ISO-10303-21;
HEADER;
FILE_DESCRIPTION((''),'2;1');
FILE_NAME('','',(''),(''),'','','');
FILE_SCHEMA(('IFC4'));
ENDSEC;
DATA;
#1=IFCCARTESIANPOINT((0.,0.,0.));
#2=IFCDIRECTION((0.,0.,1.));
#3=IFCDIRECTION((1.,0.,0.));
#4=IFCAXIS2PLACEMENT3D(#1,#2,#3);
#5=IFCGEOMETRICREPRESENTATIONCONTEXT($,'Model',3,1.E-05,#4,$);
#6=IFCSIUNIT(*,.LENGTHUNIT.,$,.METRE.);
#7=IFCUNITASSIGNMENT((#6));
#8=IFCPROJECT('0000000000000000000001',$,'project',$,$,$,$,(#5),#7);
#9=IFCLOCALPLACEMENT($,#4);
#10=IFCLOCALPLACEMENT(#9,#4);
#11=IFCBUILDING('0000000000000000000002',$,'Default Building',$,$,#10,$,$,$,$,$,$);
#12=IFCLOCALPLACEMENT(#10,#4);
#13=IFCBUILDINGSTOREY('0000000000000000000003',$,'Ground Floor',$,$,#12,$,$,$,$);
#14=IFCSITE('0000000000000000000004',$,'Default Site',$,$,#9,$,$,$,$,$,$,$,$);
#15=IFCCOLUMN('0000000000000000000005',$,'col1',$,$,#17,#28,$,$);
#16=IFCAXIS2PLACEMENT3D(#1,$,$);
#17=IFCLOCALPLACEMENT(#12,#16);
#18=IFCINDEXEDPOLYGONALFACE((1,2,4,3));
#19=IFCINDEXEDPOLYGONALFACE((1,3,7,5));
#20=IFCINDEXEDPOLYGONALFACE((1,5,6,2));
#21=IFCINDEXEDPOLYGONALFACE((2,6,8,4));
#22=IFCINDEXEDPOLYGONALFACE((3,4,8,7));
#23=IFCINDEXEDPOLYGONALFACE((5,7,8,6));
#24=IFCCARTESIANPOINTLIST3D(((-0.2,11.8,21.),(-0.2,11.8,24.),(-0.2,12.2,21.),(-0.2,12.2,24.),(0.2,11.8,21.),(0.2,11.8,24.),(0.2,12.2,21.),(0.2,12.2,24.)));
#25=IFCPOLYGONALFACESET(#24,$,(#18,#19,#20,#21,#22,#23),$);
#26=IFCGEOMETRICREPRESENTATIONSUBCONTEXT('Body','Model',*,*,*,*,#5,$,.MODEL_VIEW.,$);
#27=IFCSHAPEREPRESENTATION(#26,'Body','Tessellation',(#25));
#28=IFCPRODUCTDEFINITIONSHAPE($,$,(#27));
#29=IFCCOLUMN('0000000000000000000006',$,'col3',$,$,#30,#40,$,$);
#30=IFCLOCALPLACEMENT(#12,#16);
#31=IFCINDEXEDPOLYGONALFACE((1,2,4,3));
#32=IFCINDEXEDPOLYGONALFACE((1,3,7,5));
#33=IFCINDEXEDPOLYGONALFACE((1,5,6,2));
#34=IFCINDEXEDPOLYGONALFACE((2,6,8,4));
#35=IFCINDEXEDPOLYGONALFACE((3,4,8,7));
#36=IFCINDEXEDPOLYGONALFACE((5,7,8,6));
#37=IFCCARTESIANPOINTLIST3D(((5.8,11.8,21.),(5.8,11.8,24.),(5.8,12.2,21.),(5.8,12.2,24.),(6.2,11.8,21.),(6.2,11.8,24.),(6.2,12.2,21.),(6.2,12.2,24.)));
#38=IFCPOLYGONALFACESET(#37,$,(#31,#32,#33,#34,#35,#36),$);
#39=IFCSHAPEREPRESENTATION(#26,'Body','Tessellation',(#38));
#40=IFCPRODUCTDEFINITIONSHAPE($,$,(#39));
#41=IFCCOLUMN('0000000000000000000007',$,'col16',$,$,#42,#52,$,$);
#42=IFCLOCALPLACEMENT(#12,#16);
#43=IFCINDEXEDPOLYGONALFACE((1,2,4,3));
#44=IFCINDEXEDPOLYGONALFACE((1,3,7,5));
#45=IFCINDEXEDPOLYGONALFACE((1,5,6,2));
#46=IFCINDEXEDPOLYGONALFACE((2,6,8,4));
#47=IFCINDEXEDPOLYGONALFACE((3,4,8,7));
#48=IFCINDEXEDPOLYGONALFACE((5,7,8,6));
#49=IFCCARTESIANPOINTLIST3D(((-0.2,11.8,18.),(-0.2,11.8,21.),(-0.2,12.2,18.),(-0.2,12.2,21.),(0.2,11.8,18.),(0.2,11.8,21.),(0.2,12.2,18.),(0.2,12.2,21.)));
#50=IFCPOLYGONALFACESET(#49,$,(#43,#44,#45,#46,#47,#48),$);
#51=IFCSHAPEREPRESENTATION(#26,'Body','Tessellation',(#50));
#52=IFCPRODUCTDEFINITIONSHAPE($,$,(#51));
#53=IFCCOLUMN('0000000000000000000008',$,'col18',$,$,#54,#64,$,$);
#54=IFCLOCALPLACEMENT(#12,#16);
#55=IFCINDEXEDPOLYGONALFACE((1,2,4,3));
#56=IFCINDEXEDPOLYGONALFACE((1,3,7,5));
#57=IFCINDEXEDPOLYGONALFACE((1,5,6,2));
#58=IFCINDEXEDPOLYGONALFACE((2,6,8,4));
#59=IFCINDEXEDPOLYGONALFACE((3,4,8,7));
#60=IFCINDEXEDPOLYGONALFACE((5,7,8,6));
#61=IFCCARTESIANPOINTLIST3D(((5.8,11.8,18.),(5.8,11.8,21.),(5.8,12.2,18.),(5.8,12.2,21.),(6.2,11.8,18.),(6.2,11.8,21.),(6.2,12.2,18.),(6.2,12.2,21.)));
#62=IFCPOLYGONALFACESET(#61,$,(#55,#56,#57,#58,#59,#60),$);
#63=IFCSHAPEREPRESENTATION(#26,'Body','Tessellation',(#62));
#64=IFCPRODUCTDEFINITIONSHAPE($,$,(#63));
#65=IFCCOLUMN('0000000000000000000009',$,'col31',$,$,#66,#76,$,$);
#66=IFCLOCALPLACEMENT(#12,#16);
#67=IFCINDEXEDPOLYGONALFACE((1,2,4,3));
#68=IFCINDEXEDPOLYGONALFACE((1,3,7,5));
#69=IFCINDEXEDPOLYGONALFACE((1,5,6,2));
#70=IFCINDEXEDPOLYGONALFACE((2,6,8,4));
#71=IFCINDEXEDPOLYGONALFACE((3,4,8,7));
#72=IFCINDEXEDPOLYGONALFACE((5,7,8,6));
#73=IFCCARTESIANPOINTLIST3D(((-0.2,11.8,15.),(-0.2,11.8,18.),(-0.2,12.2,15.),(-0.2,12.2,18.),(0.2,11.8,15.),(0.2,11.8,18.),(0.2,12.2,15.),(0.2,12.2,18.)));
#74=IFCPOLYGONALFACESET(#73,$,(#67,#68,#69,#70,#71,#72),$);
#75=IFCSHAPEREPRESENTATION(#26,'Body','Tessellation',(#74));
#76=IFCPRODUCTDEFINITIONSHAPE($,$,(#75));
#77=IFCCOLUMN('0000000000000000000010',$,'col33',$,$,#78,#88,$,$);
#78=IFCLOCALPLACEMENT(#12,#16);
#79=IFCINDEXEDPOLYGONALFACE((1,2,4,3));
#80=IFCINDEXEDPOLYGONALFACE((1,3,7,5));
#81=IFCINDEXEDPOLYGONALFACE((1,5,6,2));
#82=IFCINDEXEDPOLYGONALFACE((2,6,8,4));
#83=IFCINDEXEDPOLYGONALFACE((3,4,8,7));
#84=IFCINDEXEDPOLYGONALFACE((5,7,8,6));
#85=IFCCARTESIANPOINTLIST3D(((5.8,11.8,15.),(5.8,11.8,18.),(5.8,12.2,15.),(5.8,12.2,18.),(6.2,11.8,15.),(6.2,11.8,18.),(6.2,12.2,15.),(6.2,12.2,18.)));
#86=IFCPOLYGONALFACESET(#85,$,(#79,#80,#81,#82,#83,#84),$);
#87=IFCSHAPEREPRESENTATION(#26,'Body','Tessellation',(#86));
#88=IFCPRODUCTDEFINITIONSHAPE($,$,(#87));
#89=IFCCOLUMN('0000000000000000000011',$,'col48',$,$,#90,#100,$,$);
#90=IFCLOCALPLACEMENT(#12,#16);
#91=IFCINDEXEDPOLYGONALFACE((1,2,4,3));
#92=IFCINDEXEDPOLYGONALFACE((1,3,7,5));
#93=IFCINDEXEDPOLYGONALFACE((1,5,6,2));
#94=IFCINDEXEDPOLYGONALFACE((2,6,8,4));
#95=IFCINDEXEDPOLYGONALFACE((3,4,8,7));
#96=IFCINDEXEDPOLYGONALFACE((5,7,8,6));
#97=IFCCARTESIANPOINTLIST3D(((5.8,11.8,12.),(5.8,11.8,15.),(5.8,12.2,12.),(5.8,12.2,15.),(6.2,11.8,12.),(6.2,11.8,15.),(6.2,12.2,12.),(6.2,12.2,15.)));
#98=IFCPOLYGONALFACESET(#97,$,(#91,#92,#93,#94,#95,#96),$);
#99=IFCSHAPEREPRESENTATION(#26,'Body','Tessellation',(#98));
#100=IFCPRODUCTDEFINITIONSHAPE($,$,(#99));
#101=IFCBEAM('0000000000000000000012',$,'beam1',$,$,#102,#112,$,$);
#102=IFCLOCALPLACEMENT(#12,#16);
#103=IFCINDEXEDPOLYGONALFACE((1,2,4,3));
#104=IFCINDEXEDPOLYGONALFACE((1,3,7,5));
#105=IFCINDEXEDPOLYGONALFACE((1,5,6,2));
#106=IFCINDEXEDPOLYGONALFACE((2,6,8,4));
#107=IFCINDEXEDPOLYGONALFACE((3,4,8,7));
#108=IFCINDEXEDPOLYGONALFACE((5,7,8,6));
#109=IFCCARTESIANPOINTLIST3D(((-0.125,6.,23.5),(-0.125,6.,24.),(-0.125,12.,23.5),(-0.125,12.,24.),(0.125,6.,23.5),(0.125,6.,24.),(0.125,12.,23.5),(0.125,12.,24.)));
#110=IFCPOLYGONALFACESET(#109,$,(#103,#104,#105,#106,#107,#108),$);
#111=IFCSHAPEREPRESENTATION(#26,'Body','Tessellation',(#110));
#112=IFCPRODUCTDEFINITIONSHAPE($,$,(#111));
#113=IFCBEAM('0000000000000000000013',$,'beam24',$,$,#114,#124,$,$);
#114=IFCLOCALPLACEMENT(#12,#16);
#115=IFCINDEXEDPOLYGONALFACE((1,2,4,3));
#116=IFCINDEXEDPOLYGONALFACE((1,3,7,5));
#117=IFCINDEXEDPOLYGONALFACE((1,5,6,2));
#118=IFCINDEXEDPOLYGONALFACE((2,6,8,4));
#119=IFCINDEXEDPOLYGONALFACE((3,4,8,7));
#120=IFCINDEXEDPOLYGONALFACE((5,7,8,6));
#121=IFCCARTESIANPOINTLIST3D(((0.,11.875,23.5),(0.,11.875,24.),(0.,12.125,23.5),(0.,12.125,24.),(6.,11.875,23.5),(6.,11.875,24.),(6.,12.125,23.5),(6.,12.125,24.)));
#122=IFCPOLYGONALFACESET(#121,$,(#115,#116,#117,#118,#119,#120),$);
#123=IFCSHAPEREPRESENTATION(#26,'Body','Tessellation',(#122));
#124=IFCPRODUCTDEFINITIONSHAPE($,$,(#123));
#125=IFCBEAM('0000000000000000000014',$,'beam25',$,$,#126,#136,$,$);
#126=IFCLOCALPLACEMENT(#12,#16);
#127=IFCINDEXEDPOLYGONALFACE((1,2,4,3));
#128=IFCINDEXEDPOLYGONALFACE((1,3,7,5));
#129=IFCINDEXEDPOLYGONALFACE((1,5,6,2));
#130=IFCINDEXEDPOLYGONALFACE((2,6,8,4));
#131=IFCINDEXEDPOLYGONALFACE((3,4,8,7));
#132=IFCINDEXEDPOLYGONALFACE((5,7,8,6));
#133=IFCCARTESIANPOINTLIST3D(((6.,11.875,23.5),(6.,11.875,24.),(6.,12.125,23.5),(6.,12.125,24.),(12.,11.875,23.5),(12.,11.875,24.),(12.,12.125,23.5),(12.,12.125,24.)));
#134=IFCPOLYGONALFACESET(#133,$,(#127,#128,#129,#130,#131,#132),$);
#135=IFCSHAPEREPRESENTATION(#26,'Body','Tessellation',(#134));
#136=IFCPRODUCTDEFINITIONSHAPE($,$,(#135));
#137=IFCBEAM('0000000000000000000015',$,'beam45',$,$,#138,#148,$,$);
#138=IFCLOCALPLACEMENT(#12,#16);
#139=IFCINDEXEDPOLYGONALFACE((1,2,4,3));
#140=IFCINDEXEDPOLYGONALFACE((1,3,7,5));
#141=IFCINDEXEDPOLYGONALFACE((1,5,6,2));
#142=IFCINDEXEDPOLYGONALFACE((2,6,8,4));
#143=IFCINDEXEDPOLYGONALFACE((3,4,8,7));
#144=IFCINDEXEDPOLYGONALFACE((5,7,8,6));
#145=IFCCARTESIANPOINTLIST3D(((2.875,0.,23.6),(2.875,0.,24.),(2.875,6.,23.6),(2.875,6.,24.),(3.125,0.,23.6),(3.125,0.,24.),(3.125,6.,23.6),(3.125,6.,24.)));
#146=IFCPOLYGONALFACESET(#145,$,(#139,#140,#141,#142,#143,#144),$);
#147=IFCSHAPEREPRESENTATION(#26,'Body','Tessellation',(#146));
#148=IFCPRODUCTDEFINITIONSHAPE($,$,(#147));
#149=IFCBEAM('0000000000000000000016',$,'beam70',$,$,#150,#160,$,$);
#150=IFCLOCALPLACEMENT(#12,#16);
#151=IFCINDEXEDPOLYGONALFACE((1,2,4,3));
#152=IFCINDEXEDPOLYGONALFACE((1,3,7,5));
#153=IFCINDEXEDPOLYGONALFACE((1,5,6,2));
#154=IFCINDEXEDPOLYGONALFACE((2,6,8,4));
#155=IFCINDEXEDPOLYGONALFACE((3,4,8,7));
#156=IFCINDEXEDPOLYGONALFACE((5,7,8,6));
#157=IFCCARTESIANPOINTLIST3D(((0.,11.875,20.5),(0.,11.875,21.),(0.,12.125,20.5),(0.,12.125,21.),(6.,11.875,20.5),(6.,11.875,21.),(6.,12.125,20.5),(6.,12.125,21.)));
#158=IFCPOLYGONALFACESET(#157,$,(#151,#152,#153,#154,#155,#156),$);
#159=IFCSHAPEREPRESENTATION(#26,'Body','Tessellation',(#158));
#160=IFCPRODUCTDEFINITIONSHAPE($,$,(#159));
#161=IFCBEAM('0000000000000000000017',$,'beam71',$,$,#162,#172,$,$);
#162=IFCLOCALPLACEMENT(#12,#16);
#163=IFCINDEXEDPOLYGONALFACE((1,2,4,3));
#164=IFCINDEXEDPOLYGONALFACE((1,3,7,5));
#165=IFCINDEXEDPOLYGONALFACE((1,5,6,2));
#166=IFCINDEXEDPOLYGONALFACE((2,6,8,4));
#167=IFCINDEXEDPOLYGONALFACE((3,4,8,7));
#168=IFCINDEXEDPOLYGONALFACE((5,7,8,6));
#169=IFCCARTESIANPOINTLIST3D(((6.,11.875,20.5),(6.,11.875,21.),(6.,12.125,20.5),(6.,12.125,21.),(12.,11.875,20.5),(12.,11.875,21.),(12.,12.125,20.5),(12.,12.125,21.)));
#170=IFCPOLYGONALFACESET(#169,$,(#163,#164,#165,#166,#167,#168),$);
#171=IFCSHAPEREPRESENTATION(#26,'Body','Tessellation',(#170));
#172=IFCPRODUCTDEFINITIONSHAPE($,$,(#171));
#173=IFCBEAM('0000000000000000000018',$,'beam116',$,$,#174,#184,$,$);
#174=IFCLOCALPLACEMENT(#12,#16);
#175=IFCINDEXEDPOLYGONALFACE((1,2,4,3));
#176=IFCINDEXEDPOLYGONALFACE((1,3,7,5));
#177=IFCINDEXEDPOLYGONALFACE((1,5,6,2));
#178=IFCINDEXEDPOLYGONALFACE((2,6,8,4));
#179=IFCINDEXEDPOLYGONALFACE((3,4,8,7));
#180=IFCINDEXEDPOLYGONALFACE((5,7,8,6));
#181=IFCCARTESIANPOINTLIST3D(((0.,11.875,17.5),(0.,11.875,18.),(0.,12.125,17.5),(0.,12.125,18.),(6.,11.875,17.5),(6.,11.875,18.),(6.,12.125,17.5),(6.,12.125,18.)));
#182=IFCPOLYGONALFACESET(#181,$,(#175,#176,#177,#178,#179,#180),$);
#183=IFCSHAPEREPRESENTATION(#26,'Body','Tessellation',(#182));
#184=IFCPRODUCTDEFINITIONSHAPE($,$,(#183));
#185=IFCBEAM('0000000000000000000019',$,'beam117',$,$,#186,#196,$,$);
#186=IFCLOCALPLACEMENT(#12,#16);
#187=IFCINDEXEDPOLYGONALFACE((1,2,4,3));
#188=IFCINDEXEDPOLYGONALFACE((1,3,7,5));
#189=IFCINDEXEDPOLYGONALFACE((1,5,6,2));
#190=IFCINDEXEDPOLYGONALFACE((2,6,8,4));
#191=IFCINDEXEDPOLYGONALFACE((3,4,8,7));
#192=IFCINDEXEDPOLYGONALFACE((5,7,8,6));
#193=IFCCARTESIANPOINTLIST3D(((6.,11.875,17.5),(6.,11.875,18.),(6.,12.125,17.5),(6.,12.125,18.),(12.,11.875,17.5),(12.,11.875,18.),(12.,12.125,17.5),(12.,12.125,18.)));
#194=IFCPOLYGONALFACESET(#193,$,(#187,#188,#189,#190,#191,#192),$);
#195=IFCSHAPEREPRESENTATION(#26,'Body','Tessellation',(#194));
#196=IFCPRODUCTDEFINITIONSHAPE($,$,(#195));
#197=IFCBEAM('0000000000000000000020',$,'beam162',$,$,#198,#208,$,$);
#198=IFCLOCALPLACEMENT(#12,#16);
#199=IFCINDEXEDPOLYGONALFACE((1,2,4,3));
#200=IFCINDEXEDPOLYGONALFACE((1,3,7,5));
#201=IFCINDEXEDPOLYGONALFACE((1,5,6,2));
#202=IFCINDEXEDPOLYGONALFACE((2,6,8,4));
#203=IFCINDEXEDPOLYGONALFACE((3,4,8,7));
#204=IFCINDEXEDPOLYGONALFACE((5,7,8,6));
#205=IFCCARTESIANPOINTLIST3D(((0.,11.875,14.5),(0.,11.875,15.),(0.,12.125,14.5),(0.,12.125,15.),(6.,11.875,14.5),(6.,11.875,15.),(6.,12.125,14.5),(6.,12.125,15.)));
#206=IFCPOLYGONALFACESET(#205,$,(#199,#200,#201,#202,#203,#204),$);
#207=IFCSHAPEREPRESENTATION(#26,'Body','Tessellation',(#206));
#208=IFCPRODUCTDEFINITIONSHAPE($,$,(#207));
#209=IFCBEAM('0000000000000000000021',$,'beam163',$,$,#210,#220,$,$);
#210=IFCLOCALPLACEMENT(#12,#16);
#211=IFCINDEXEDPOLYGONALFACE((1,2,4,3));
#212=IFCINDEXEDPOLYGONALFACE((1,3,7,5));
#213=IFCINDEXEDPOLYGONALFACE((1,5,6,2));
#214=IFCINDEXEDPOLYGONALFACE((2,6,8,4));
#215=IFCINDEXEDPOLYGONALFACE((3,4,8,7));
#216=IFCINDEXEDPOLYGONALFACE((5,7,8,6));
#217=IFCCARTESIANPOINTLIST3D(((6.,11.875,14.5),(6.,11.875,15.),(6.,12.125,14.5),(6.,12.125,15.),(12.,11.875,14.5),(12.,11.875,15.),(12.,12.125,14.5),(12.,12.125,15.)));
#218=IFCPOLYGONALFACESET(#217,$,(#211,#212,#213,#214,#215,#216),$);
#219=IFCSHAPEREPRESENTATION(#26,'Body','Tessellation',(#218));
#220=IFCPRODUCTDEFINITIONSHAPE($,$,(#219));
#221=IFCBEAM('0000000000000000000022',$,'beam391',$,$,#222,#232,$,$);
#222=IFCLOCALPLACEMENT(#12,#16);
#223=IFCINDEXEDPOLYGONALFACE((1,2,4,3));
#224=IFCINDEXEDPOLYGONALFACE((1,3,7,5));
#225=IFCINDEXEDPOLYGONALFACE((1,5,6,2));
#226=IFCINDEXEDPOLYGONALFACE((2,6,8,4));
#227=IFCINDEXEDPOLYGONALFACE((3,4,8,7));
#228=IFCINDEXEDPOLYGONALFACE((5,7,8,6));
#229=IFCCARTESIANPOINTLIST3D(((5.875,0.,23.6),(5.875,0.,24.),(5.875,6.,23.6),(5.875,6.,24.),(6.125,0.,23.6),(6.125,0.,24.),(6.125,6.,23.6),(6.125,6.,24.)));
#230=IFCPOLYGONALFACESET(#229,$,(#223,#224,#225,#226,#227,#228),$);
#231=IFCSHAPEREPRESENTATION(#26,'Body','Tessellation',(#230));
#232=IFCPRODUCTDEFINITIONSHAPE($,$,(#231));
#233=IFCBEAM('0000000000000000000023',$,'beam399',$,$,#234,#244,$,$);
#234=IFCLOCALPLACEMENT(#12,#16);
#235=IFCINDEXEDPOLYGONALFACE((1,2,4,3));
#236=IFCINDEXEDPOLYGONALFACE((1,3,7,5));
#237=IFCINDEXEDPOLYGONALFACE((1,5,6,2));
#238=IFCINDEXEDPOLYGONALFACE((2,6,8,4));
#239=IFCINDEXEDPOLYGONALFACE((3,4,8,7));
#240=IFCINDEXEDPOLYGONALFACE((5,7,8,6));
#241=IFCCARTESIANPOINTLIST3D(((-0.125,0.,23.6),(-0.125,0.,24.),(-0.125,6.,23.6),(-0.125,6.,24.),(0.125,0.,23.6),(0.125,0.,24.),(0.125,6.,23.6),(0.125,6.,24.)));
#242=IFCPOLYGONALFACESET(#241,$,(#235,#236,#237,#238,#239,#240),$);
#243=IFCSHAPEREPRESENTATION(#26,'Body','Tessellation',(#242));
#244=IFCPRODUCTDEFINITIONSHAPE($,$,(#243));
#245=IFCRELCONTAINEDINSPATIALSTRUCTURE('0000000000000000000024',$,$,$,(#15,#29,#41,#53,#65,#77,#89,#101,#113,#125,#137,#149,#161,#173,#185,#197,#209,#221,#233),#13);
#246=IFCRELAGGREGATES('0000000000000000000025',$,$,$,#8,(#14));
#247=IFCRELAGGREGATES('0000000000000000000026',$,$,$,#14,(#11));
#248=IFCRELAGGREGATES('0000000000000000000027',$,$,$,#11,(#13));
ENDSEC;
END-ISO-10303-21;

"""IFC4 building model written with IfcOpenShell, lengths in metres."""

from ifc_helpers import new_model, si_unit, frame, origin_with_axes, place, context, subcontext, project, spatial, indexed_curve, outline, extrude, element, save


model = new_model("IFC4")

# Units and contexts
model_context = context("Model", 3, precision=1e-05, world=origin_with_axes())
body_context = subcontext(model_context, "Body", "Model", "MODEL_VIEW")
ifc_project = project(units=[si_unit("LENGTHUNIT", "METRE")], contexts=[model_context])

# Site, building, storey
site_placement = place(None, origin_with_axes())
site = spatial("IfcSite", under=ifc_project, at=site_placement, Name="Default Site")
building_placement = place(site_placement, origin_with_axes())
building = spatial("IfcBuilding", under=site, at=building_placement, Name="Default Building")
storey_placement = place(building_placement, origin_with_axes())
storey = spatial("IfcBuildingStorey", under=building, at=storey_placement, Name="Ground Floor")

# Columns
for number, where, z_axis, x_axis, name in (
    (1, (-0.2, 11.8, 21.0), (0.0, 0.0, 1.0), (1.0, 0.0, 0.0), "col1"),
    (2, (5.8, 11.8, 21.0), (0.0, 0.0, 1.0), (1.0, 0.0, 0.0), "col3"),
    (3, (-0.2, 11.8, 18.0), (0.0, 0.0, 1.0), (1.0, 0.0, 0.0), "col16"),
    (4, (5.8, 11.8, 18.0), (0.0, 0.0, 1.0), (1.0, 0.0, 0.0), "col18"),
    (5, (-0.2, 11.8, 15.0), (0.0, 0.0, 1.0), (1.0, 0.0, 0.0), "col31"),
    (6, (5.8, 11.8, 15.0), (0.0, 0.0, 1.0), (1.0, 0.0, 0.0), "col33"),
    (7, (5.8, 11.8, 12.0), (0.0, 0.0, 1.0), (1.0, 0.0, 0.0), "col48"),
):
    element("IfcColumn", number, at=place(storey_placement, frame(where, z_axis=z_axis, x_axis=x_axis)), inside=storey, Name=name, context=body_context, shape_type="SweptSolid", body=[
        extrude(outline(indexed_curve([(0.0, 0.0), (0.0, 0.4), (0.4, 0.4), (0.4, 0.0), (0.0, 0.0)], self_intersect=False)), origin_with_axes(), (0.0, 0.0, 1.0), 3.0),
    ])

# Beams
for number, where, z_axis, x_axis, name in (
    (8, (0.125, 6.0, 23.5), (0.0, 0.0, 1.0), (0.0, 1.0, 0.0), "beam1"),
    (9, (0.0, 11.875, 23.5), (0.0, 0.0, 1.0), (1.0, 0.0, 0.0), "beam24"),
    (10, (6.0, 11.875, 23.5), (0.0, 0.0, 1.0), (1.0, 0.0, 0.0), "beam25"),
):
    element("IfcBeam", number, at=place(storey_placement, frame(where, z_axis=z_axis, x_axis=x_axis)), inside=storey, Name=name, context=body_context, shape_type="SweptSolid", body=[
        extrude(outline(indexed_curve([(0.0, 0.0), (0.0, 0.25), (6.0, 0.25), (6.0, 0.0), (0.0, 0.0)], self_intersect=False)), origin_with_axes(), (0.0, 0.0, 1.0), 0.5),
    ])
beam_placement = place(storey_placement, frame((2.875, 6.0, 23.6), z_axis=(0.0, 0.0, 1.0), x_axis=(0.0, -1.0, 0.0)))
element("IfcBeam", 11, at=beam_placement, inside=storey, Name="beam45", context=body_context, shape_type="SweptSolid", body=[
    extrude(outline(indexed_curve([(0.0, 0.0), (0.0, 0.25), (6.0, 0.25), (6.0, 0.0), (0.0, 0.0)], self_intersect=False)), origin_with_axes(), (0.0, 0.0, 1.0), 0.4),
])
for number, where, z_axis, x_axis, name in (
    (12, (0.0, 11.875, 20.5), (0.0, 0.0, 1.0), (1.0, 0.0, 0.0), "beam70"),
    (13, (6.0, 11.875, 20.5), (0.0, 0.0, 1.0), (1.0, 0.0, 0.0), "beam71"),
    (14, (0.0, 11.875, 17.5), (0.0, 0.0, 1.0), (1.0, 0.0, 0.0), "beam116"),
    (15, (6.0, 11.875, 17.5), (0.0, 0.0, 1.0), (1.0, 0.0, 0.0), "beam117"),
    (16, (0.0, 11.875, 14.5), (0.0, 0.0, 1.0), (1.0, 0.0, 0.0), "beam162"),
    (17, (6.0, 11.875, 14.5), (0.0, 0.0, 1.0), (1.0, 0.0, 0.0), "beam163"),
):
    element("IfcBeam", number, at=place(storey_placement, frame(where, z_axis=z_axis, x_axis=x_axis)), inside=storey, Name=name, context=body_context, shape_type="SweptSolid", body=[
        extrude(outline(indexed_curve([(0.0, 0.0), (0.0, 0.25), (6.0, 0.25), (6.0, 0.0), (0.0, 0.0)], self_intersect=False)), origin_with_axes(), (0.0, 0.0, 1.0), 0.5),
    ])
for number, where, z_axis, x_axis, name in (
    (18, (5.875, 6.0, 23.6), (0.0, 0.0, 1.0), (0.0, -1.0, 0.0), "beam391"),
    (19, (-0.125, 6.0, 23.6), (0.0, 0.0, 1.0), (0.0, -1.0, 0.0), "beam399"),
):
    element("IfcBeam", number, at=place(storey_placement, frame(where, z_axis=z_axis, x_axis=x_axis)), inside=storey, Name=name, context=body_context, shape_type="SweptSolid", body=[
        extrude(outline(indexed_curve([(0.0, 0.0), (0.0, 0.25), (6.0, 0.25), (6.0, 0.0), (0.0, 0.0)], self_intersect=False)), origin_with_axes(), (0.0, 0.0, 1.0), 0.4),
    ])

save(model, "model.ifc")
